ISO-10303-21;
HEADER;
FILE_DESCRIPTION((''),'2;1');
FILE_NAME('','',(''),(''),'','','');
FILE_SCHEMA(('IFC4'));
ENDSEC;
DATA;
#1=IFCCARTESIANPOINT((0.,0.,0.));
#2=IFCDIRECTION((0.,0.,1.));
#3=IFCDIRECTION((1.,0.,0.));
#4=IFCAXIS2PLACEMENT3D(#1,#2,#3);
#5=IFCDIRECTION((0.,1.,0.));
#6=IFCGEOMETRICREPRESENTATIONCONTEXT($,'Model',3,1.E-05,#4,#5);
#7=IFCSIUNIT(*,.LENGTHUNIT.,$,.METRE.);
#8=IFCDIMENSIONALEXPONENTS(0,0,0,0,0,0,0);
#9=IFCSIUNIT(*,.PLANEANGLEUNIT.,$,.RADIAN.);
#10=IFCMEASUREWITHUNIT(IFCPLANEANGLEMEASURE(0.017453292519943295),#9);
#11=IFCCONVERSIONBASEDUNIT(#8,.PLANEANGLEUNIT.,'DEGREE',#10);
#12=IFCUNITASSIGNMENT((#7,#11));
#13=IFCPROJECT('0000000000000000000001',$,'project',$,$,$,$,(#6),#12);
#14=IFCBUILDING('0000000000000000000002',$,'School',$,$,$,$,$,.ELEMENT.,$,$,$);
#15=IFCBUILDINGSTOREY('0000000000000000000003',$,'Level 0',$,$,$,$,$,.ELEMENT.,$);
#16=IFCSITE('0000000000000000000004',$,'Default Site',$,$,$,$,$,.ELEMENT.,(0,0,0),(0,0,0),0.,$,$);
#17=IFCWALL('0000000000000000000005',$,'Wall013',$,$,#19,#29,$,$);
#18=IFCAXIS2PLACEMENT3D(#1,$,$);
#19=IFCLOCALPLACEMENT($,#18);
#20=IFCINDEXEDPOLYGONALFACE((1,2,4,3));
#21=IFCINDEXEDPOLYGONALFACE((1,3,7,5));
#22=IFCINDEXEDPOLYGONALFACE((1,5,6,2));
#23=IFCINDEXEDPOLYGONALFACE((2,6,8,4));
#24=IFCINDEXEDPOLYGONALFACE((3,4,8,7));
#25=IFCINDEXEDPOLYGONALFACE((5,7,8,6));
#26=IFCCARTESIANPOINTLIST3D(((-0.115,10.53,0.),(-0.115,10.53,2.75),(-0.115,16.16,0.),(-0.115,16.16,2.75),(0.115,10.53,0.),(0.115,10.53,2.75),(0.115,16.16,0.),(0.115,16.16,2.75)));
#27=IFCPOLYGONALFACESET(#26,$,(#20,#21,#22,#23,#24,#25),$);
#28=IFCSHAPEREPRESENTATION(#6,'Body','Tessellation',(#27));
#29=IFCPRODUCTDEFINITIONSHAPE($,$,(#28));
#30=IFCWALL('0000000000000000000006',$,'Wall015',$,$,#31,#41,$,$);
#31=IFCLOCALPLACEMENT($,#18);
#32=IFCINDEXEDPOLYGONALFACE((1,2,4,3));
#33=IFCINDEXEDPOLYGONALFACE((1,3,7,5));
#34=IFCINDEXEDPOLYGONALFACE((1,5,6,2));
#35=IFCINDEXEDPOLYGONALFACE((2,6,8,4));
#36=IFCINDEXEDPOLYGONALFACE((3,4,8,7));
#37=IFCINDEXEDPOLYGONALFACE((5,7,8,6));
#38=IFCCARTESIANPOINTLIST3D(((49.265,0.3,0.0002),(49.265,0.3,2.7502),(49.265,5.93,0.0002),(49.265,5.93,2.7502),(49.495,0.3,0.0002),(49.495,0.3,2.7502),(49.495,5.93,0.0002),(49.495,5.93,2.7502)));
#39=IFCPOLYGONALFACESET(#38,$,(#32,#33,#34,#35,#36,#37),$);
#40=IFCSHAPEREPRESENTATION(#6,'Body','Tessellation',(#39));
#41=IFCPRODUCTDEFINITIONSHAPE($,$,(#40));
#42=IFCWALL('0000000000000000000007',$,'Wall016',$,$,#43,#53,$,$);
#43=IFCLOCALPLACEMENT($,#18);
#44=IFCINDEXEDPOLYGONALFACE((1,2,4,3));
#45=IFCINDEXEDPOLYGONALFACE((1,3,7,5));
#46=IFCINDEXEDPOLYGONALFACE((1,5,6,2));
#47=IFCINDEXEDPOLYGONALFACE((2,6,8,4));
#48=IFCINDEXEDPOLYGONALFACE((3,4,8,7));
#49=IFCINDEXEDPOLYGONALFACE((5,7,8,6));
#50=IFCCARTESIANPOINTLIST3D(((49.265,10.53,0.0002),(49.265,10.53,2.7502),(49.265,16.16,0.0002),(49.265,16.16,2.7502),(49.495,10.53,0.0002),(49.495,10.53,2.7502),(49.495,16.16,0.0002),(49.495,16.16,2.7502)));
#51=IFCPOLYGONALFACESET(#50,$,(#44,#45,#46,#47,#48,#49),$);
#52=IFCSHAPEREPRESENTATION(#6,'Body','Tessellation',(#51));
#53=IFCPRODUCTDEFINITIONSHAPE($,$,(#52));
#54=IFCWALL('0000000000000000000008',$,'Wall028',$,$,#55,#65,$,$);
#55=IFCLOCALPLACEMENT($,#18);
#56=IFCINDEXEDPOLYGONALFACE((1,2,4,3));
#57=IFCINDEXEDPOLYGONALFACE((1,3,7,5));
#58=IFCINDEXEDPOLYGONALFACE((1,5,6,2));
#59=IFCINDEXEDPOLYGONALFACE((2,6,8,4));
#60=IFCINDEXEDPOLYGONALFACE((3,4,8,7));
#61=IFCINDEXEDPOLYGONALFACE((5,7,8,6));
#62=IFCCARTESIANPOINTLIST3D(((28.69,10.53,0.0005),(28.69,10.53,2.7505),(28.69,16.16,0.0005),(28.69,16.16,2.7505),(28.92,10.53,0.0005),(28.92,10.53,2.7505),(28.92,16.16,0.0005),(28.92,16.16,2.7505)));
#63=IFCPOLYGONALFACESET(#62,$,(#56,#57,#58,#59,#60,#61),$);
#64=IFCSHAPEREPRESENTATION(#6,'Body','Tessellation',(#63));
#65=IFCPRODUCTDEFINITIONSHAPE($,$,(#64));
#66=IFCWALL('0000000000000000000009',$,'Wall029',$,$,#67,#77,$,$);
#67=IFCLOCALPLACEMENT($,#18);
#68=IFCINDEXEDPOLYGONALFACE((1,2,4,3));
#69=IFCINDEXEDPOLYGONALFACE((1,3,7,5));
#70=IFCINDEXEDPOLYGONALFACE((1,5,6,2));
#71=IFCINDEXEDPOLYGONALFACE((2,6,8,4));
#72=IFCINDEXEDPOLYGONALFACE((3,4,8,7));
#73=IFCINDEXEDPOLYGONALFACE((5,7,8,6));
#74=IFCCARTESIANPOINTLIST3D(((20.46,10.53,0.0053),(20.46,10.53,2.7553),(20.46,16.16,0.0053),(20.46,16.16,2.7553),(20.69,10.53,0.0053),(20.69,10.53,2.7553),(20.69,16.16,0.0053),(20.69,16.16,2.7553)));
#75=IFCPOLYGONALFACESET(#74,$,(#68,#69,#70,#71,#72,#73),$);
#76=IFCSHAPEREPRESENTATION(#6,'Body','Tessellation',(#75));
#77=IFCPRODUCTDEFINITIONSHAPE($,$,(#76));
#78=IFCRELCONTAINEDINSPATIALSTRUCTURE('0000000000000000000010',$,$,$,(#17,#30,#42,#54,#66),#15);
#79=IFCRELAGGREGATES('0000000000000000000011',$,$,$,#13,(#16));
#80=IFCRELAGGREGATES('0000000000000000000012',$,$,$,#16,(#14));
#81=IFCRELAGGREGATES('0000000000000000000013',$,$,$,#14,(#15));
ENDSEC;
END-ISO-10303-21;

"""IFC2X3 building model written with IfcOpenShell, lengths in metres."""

from ifc_helpers import new_model, entity, si_unit, converted_unit, direction, frame, frame_2d, origin_with_axes, place, context, project, spatial, rectangle, extrude, element, save


model = new_model("IFC2X3")

# Units and contexts
model_context = context("Model", 3, precision=1e-05, world=origin_with_axes(), true_north=direction((0.0, 1.0, 0.0)))
ifc_project = project(units=[si_unit("LENGTHUNIT", "METRE"), converted_unit("PLANEANGLEUNIT", "DEGREE", entity("IfcPlaneAngleMeasure", 0.017453292519943295), si_unit("PLANEANGLEUNIT", "RADIAN"), dimensions=[0, 0, 0, 0, 0, 0, 0])], contexts=[model_context])

# Site, building, storey
site = spatial("IfcSite", under=ifc_project, Name="Default Site", CompositionType="ELEMENT", RefLatitude=(0, 0, 0), RefLongitude=(0, 0, 0), RefElevation=0.0)
building = spatial("IfcBuilding", under=site, Name="School", CompositionType="ELEMENT")
storey = spatial("IfcBuildingStorey", under=building, Name="Level 0", CompositionType="ELEMENT")

# Shared definitions
placement = place(None, origin_with_axes())

# Walls
element("IfcWall", 1, at=placement, inside=storey, Name="Wall013", context=model_context, shape_type="SweptSolid", body=[
    extrude(rectangle(XDim=5.63, YDim=0.23, at=frame_2d((0.0, 0.0), x_axis=(0.0, 1.0, 0.0))), frame((0.0, 13.345, 0.0), z_axis=(0.0, 0.0, 1.0), x_axis=(1.0, 0.0, 0.0)), (0.0, 0.0, 1.0), 2.75),
])
element("IfcWall", 2, at=placement, inside=storey, Name="Wall015", context=model_context, shape_type="SweptSolid", body=[
    extrude(rectangle(XDim=5.63, YDim=0.23, at=frame_2d((0.0, 0.0), x_axis=(0.0, 1.0, 0.0))), frame((49.38, 3.115, 0.0002), z_axis=(0.0, 0.0, 1.0), x_axis=(1.0, 0.0, 0.0)), (0.0, 0.0, 1.0), 2.75),
])
element("IfcWall", 3, at=placement, inside=storey, Name="Wall016", context=model_context, shape_type="SweptSolid", body=[
    extrude(rectangle(XDim=5.63, YDim=0.23, at=frame_2d((0.0, 0.0), x_axis=(0.0, 1.0, 0.0))), frame((49.38, 13.345, 0.0002), z_axis=(0.0, 0.0, 1.0), x_axis=(1.0, 0.0, 0.0)), (0.0, 0.0, 1.0), 2.75),
])
element("IfcWall", 4, at=placement, inside=storey, Name="Wall028", context=model_context, shape_type="SweptSolid", body=[
    extrude(rectangle(XDim=5.63, YDim=0.23, at=frame_2d((0.0, 0.0), x_axis=(0.0, 1.0, 0.0))), frame((28.805, 13.345, 0.0005), z_axis=(0.0, 0.0, 1.0), x_axis=(1.0, 0.0, 0.0)), (0.0, 0.0, 1.0), 2.75),
])
element("IfcWall", 5, at=placement, inside=storey, Name="Wall029", context=model_context, shape_type="SweptSolid", body=[
    extrude(rectangle(XDim=5.63, YDim=0.23, at=frame_2d((0.0, 0.0), x_axis=(0.0, 1.0, 0.0))), frame((20.575, 13.345, 0.0053), z_axis=(0.0, 0.0, 1.0), x_axis=(1.0, 0.0, 0.0)), (0.0, 0.0, 1.0), 2.75),
])

save(model, "model.ifc")
